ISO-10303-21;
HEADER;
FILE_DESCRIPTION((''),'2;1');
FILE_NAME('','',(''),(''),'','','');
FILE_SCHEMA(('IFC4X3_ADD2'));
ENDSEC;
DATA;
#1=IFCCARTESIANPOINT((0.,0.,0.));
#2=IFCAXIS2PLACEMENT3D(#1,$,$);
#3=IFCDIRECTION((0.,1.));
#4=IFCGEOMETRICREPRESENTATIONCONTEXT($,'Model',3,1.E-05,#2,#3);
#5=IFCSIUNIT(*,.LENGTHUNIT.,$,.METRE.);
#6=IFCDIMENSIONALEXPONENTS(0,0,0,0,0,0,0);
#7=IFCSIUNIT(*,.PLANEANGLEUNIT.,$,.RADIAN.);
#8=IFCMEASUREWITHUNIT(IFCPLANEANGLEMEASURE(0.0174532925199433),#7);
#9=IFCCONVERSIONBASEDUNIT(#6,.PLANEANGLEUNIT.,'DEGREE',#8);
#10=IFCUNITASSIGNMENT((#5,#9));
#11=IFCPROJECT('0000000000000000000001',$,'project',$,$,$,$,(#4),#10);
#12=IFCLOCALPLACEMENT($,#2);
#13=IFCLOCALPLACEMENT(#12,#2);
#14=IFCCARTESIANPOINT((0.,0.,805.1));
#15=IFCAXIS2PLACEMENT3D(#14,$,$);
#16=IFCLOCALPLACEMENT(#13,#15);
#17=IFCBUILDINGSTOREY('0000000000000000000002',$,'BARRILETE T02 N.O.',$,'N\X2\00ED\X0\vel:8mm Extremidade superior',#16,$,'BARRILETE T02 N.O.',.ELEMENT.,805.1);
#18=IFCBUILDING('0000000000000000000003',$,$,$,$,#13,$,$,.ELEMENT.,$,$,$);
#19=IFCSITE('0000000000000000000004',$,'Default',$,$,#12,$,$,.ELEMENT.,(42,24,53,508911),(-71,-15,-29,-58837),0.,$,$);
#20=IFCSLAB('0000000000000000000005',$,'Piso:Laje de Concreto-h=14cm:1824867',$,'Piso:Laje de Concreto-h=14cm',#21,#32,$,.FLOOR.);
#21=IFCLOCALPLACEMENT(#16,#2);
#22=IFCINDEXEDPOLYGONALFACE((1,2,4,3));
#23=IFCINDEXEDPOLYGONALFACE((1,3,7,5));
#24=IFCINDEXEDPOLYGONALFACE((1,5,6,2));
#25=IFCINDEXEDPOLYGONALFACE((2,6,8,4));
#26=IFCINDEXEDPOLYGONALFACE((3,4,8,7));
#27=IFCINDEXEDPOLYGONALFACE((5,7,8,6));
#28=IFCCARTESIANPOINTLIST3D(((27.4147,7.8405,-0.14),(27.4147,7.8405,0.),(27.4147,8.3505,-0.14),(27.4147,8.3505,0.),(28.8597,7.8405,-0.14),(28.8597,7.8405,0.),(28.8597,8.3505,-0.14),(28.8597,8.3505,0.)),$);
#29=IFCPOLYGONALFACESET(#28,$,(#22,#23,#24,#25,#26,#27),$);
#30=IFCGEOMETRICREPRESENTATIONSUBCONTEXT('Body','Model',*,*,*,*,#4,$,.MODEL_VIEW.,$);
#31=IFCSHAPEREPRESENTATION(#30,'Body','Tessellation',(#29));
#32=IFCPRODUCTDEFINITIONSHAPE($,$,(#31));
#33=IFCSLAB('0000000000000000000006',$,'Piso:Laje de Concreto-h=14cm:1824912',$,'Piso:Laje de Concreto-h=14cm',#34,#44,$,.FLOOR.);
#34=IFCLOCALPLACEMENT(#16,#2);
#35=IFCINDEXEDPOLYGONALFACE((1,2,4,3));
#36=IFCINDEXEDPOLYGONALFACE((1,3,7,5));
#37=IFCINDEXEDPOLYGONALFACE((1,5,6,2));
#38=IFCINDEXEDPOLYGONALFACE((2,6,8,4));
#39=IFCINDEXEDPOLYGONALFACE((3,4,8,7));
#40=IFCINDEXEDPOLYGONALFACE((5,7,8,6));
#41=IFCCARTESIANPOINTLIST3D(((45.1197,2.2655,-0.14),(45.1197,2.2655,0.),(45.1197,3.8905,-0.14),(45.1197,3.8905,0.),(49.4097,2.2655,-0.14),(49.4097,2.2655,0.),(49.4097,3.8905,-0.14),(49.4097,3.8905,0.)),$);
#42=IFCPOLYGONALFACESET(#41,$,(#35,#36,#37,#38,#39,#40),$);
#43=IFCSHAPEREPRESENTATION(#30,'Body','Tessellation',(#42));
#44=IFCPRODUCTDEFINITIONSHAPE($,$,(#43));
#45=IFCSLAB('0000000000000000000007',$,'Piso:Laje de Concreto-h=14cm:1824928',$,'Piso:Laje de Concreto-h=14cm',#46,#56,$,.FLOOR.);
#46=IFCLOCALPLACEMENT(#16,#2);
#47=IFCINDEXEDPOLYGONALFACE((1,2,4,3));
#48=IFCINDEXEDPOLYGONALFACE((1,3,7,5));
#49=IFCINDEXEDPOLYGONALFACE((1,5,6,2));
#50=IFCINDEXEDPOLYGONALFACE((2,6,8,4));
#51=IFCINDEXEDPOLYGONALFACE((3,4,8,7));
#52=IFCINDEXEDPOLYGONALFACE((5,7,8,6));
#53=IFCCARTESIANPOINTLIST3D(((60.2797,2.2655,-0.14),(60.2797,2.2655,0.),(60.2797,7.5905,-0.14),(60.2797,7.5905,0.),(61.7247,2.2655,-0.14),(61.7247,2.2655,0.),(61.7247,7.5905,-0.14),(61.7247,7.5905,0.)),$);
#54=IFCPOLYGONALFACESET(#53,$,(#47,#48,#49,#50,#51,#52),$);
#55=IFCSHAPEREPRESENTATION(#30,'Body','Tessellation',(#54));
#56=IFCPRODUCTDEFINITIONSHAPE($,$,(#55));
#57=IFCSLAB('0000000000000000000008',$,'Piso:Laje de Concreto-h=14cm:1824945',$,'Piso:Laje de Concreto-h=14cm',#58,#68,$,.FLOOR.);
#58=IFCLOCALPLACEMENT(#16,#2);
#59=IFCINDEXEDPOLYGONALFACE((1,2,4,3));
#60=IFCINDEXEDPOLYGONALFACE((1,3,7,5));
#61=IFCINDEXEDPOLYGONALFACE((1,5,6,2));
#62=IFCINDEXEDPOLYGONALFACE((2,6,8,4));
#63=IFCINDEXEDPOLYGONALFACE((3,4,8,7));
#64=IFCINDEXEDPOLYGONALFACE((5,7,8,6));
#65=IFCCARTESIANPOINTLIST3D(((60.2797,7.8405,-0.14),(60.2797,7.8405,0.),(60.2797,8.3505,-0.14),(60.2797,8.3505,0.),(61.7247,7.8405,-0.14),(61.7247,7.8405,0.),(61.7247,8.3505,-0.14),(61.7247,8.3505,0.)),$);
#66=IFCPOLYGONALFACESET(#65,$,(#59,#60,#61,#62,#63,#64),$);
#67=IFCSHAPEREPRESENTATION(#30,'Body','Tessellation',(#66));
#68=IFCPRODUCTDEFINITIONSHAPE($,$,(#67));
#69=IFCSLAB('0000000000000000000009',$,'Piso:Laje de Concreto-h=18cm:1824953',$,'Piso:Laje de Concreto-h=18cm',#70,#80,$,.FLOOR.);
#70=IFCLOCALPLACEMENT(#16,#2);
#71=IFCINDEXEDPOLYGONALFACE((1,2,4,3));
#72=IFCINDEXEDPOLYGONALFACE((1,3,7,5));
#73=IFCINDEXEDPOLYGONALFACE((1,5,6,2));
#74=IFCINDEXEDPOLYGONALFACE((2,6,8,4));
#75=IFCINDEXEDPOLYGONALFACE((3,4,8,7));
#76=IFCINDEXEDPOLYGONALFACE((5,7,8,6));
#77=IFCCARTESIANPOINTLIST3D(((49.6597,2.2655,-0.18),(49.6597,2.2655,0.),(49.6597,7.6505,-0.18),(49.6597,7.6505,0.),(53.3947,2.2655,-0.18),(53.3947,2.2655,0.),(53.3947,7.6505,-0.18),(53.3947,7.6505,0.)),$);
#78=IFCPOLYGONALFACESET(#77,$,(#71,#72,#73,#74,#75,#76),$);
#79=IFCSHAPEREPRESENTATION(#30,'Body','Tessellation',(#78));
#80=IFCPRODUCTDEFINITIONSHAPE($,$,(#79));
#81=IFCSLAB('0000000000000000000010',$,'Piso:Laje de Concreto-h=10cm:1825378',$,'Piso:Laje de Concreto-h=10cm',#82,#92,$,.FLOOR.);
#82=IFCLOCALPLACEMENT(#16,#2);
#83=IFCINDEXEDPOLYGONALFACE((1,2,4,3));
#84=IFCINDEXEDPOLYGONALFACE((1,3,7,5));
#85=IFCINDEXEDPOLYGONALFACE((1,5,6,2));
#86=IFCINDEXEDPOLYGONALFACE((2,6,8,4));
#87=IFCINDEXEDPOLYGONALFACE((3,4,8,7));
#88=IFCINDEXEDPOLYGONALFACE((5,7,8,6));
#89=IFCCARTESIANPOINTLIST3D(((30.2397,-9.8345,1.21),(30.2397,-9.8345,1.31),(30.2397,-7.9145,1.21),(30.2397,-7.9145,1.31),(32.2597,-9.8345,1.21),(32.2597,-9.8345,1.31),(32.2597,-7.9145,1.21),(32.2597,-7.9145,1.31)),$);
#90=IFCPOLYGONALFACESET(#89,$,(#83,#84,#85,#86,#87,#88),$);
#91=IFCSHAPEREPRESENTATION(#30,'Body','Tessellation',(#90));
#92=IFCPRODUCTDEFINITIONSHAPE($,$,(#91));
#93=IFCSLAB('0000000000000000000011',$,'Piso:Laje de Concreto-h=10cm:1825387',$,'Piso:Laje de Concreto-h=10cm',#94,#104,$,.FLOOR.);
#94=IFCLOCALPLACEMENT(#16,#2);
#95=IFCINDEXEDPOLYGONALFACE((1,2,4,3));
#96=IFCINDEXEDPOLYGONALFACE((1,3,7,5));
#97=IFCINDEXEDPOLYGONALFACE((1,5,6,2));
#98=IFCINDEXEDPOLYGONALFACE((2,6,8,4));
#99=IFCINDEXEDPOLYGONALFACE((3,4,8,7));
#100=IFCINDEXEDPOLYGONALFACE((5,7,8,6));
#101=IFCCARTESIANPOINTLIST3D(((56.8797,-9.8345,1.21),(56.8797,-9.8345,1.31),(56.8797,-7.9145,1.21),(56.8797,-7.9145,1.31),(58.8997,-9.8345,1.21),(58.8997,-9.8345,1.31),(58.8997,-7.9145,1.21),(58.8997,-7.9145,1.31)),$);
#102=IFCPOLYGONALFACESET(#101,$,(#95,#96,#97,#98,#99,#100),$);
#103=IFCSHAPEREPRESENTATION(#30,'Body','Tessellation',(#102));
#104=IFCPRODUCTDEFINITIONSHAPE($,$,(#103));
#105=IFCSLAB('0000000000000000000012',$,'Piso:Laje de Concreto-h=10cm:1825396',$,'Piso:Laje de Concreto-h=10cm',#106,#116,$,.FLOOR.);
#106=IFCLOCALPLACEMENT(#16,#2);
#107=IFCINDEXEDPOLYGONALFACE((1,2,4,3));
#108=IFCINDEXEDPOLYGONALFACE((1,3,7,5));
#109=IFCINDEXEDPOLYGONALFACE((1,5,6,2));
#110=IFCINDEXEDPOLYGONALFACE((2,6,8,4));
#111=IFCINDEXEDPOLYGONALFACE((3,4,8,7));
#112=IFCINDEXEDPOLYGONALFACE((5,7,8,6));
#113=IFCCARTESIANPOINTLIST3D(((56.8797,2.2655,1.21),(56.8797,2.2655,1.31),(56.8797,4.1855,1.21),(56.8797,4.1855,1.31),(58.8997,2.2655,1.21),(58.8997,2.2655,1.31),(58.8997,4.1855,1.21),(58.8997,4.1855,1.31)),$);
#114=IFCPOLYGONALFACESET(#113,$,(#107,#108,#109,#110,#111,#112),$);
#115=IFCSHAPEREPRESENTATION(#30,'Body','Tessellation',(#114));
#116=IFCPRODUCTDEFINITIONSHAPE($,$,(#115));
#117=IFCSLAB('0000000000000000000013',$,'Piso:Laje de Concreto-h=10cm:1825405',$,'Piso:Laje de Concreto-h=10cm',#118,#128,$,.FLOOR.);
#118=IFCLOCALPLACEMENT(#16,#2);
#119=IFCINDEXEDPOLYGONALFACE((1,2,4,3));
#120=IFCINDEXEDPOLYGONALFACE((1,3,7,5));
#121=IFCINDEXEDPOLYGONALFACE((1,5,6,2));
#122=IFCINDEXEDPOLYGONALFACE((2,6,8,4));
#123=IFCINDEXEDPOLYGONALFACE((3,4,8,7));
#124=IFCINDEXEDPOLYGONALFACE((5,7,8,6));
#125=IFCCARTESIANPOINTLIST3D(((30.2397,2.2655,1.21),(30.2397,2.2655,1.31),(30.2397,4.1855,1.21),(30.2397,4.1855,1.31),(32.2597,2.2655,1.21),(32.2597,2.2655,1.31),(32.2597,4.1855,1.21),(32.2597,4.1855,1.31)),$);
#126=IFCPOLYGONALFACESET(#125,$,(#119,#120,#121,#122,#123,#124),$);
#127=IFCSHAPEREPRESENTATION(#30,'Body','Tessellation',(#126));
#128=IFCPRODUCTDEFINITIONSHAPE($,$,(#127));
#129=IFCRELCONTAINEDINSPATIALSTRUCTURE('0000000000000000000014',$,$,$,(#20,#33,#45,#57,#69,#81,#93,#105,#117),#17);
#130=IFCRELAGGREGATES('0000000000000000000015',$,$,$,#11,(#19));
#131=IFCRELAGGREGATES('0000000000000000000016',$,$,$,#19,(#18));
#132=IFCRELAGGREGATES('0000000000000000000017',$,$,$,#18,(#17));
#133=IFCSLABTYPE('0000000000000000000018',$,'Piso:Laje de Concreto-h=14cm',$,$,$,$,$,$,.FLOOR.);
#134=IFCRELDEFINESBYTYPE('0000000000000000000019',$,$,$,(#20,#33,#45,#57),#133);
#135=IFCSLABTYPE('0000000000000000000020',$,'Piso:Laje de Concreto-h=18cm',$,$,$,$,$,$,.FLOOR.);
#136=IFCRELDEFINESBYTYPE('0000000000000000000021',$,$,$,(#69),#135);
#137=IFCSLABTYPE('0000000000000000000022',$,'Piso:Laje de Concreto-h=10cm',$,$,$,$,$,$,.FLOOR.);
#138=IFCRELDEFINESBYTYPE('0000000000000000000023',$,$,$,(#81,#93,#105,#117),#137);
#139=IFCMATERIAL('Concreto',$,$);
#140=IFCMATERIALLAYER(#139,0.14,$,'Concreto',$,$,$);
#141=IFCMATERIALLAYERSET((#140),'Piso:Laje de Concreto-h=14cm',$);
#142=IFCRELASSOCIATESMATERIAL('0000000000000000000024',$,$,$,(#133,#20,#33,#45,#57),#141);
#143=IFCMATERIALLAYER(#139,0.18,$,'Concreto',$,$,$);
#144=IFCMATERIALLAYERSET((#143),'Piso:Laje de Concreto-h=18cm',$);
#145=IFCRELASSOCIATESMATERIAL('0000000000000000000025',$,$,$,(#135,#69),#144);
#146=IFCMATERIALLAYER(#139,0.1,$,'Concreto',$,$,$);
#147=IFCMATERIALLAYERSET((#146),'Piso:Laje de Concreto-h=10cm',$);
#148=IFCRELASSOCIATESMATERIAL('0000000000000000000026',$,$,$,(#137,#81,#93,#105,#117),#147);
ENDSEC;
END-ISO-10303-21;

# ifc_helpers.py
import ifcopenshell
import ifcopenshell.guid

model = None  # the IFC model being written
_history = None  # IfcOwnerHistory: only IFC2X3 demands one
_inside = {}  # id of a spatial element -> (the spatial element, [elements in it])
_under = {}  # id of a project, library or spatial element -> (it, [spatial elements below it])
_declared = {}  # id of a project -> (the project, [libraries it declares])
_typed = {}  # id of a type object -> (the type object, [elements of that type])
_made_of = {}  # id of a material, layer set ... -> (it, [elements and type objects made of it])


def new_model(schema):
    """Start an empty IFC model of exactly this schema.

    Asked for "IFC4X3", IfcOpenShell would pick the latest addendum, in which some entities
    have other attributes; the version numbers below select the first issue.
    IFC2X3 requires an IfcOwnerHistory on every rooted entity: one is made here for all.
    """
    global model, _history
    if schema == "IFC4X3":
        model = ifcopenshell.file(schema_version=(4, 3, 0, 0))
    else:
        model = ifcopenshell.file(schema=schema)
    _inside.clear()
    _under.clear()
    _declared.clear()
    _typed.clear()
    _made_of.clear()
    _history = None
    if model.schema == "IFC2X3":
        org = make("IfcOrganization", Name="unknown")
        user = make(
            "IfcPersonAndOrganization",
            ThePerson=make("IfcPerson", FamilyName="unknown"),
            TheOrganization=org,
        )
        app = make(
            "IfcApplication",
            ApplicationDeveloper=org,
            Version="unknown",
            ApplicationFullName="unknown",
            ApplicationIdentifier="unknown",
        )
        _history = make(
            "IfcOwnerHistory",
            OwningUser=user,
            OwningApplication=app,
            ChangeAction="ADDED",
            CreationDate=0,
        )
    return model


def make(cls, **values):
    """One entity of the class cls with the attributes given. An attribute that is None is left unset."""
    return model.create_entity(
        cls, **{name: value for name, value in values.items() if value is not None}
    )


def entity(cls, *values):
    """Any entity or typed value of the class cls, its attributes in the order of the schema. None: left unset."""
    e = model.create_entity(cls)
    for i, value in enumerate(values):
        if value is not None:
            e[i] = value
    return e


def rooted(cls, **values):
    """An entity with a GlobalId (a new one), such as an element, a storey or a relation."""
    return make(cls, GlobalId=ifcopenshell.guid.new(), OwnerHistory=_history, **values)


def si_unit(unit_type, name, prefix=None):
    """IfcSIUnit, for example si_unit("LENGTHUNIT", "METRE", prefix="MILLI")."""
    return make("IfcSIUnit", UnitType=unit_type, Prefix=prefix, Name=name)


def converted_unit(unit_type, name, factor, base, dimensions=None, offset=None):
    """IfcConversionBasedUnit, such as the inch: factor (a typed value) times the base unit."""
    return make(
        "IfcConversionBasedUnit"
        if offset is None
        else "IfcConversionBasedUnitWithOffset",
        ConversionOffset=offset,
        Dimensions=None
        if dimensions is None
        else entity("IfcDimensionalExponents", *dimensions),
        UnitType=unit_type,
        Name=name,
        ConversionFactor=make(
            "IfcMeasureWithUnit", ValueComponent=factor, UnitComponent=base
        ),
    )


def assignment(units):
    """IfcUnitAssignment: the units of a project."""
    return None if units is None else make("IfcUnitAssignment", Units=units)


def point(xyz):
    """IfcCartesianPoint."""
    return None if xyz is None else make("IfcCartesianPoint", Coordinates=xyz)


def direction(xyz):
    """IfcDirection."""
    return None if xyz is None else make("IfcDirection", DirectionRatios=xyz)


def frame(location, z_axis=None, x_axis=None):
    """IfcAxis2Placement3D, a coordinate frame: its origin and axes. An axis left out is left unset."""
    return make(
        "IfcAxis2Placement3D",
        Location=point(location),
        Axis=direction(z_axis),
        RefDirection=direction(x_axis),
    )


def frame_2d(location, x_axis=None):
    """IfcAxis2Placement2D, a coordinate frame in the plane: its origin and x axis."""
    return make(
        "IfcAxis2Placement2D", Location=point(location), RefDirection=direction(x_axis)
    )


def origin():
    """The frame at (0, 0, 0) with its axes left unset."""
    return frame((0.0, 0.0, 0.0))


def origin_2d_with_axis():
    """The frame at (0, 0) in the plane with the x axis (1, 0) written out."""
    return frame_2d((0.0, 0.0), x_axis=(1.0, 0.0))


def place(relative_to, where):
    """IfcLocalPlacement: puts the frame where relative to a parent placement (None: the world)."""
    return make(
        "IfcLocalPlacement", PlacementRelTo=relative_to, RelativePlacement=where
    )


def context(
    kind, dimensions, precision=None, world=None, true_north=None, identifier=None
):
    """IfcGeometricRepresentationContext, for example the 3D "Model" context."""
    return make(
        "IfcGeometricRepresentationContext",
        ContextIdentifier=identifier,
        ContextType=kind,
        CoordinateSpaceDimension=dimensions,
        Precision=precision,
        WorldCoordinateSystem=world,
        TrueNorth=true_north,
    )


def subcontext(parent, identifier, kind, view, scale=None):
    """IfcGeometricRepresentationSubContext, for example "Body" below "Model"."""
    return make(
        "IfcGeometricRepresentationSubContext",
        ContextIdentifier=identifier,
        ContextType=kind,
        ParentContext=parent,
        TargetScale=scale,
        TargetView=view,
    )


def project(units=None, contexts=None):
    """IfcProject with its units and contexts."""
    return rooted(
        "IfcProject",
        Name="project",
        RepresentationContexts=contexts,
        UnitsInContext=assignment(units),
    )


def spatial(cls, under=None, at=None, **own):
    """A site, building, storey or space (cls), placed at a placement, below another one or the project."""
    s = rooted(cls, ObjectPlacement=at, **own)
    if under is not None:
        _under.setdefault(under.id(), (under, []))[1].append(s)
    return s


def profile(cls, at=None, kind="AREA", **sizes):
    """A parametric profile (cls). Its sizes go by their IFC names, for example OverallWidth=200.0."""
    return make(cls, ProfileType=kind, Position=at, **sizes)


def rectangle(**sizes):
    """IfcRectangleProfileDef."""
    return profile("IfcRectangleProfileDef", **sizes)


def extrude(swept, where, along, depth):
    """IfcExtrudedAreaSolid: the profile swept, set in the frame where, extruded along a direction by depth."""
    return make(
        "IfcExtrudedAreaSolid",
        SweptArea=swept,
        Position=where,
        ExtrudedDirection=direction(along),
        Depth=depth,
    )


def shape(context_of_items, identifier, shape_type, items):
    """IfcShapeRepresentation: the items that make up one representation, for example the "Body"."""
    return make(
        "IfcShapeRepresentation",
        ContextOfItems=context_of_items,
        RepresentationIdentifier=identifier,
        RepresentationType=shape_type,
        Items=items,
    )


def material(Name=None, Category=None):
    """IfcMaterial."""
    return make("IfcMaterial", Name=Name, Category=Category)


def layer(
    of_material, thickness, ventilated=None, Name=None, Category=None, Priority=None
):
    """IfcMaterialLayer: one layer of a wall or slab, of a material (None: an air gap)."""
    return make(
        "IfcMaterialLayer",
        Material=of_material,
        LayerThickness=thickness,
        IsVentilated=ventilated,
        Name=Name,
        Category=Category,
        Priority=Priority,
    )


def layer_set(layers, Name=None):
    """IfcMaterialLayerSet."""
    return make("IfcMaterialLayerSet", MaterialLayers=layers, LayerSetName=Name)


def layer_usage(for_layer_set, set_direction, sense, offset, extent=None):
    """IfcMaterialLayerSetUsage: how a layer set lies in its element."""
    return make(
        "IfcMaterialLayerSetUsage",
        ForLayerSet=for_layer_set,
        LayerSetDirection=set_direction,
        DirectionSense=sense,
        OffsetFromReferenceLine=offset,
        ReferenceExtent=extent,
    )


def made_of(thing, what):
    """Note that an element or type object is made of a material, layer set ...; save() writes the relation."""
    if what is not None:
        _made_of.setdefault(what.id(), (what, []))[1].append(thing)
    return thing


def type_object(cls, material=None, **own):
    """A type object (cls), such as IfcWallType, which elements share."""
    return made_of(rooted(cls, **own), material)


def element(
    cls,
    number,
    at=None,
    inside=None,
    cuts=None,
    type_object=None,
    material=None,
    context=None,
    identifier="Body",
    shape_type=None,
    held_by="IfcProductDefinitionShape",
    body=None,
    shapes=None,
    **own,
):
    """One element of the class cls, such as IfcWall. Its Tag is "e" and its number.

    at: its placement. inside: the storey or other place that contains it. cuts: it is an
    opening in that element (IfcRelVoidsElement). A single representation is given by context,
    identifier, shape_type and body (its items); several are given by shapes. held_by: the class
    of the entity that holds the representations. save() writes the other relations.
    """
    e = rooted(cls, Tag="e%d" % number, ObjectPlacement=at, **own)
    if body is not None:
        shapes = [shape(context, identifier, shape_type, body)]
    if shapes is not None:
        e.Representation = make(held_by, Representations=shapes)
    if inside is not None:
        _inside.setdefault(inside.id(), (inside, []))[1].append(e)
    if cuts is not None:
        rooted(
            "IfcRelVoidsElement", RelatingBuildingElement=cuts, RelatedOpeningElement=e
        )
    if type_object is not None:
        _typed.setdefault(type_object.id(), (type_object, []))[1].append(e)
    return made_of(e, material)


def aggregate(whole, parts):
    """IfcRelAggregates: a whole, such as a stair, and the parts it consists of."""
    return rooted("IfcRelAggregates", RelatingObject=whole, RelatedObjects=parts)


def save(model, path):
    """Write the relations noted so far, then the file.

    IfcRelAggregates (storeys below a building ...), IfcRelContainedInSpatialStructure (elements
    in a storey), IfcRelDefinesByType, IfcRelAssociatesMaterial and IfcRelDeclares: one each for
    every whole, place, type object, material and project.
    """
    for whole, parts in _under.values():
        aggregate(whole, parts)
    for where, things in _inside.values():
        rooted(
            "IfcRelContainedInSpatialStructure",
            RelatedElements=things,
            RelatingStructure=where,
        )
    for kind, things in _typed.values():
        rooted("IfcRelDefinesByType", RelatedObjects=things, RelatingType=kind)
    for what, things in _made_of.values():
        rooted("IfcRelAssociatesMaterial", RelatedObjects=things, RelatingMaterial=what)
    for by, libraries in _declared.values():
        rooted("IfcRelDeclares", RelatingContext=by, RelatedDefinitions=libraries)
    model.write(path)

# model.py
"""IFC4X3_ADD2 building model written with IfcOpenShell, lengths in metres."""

from ifc_helpers import new_model, entity, si_unit, converted_unit, direction, frame, frame_2d, origin, origin_2d_with_axis, place, context, subcontext, project, spatial, rectangle, extrude, material, layer, layer_set, layer_usage, type_object, element, save


model = new_model("IFC4X3_ADD2")

# Units and contexts
model_context = context("Model", 3, precision=1e-05, world=origin(), true_north=direction((0.0, 1.0)))
body_context = subcontext(model_context, "Body", "Model", "MODEL_VIEW")
ifc_project = project(units=[si_unit("LENGTHUNIT", "METRE"), converted_unit("PLANEANGLEUNIT", "DEGREE", entity("IfcPlaneAngleMeasure", 0.0174532925199433), si_unit("PLANEANGLEUNIT", "RADIAN"), dimensions=[0, 0, 0, 0, 0, 0, 0])], contexts=[model_context])

# Site, building, storey
site_placement = place(None, origin())
site = spatial("IfcSite", under=ifc_project, at=site_placement, Name="Default", CompositionType="ELEMENT", RefLatitude=(42, 24, 53, 508911), RefLongitude=(-71, -15, -29, -58837), RefElevation=0.0)
building_placement = place(site_placement, origin())
building = spatial("IfcBuilding", under=site, at=building_placement, CompositionType="ELEMENT")
storey_placement = place(building_placement, frame((0.0, 0.0, 805.1)))
storey = spatial("IfcBuildingStorey", under=building, at=storey_placement, Name="BARRILETE T02 N.O.", ObjectType="Nível:8mm Extremidade superior", LongName="BARRILETE T02 N.O.", CompositionType="ELEMENT", Elevation=805.1)

# Shared definitions
ifc_material = material(Name="Concreto")

# Slabs
ifc_layer_1 = layer(ifc_material, 0.14, Name="Concreto")
ifc_layer_set_1 = layer_set([ifc_layer_1], Name="Piso:Laje de Concreto-h=14cm")
ifc_layer_usage_1 = layer_usage(ifc_layer_set_1, "AXIS3", "POSITIVE", 0.0)
slab_type_1 = type_object("IfcSlabType", Name="Piso:Laje de Concreto-h=14cm", PredefinedType="FLOOR", material=ifc_layer_set_1)
slab_1_placement = place(storey_placement, origin())
element("IfcSlab", 1, at=slab_1_placement, inside=storey, type_object=slab_type_1, material=ifc_layer_usage_1, Name="Piso:Laje de Concreto-h=14cm:1824867", ObjectType="Piso:Laje de Concreto-h=14cm", PredefinedType="FLOOR", context=body_context, shape_type="SweptSolid", body=[
    extrude(rectangle(XDim=0.51, YDim=1.445, at=frame_2d((0.0, 0.0), x_axis=(1.0, 0.0))), frame((28.1372, 8.0955, 0.0), z_axis=(0.0, 0.0, -1.0), x_axis=(0.0, 1.0, 0.0)), (0.0, 0.0, 1.0), 0.14),
])
ifc_layer_usage_2 = layer_usage(ifc_layer_set_1, "AXIS3", "POSITIVE", 0.0)
slab_2_placement = place(storey_placement, origin())
element("IfcSlab", 2, at=slab_2_placement, inside=storey, type_object=slab_type_1, material=ifc_layer_usage_2, Name="Piso:Laje de Concreto-h=14cm:1824912", ObjectType="Piso:Laje de Concreto-h=14cm", PredefinedType="FLOOR", context=body_context, shape_type="SweptSolid", body=[
    extrude(rectangle(XDim=1.625, YDim=4.29, at=frame_2d((0.0, 0.0), x_axis=(1.0, 0.0))), frame((47.2647, 3.078, 0.0), z_axis=(0.0, 0.0, -1.0), x_axis=(0.0, 1.0, 0.0)), (0.0, 0.0, 1.0), 0.14),
])
ifc_layer_usage_3 = layer_usage(ifc_layer_set_1, "AXIS3", "POSITIVE", 0.0)
slab_3_placement = place(storey_placement, origin())
element("IfcSlab", 3, at=slab_3_placement, inside=storey, type_object=slab_type_1, material=ifc_layer_usage_3, Name="Piso:Laje de Concreto-h=14cm:1824928", ObjectType="Piso:Laje de Concreto-h=14cm", PredefinedType="FLOOR", context=body_context, shape_type="SweptSolid", body=[
    extrude(rectangle(XDim=5.325, YDim=1.445, at=frame_2d((0.0, 0.0), x_axis=(1.0, 0.0))), frame((61.0022, 4.928, 0.0), z_axis=(0.0, 0.0, -1.0), x_axis=(0.0, 1.0, 0.0)), (0.0, 0.0, 1.0), 0.14),
])
ifc_layer_usage_4 = layer_usage(ifc_layer_set_1, "AXIS3", "POSITIVE", 0.0)
slab_4_placement = place(storey_placement, origin())
element("IfcSlab", 4, at=slab_4_placement, inside=storey, type_object=slab_type_1, material=ifc_layer_usage_4, Name="Piso:Laje de Concreto-h=14cm:1824945", ObjectType="Piso:Laje de Concreto-h=14cm", PredefinedType="FLOOR", context=body_context, shape_type="SweptSolid", body=[
    extrude(rectangle(XDim=0.51, YDim=1.445, at=frame_2d((0.0, 0.0), x_axis=(1.0, 0.0))), frame((61.0022, 8.0955, 0.0), z_axis=(0.0, 0.0, -1.0), x_axis=(0.0, 1.0, 0.0)), (0.0, 0.0, 1.0), 0.14),
])
ifc_layer_2 = layer(ifc_material, 0.18, Name="Concreto")
ifc_layer_set_2 = layer_set([ifc_layer_2], Name="Piso:Laje de Concreto-h=18cm")
ifc_layer_usage_5 = layer_usage(ifc_layer_set_2, "AXIS3", "POSITIVE", 0.0)
slab_type_2 = type_object("IfcSlabType", Name="Piso:Laje de Concreto-h=18cm", PredefinedType="FLOOR", material=ifc_layer_set_2)
slab_5_placement = place(storey_placement, origin())
element("IfcSlab", 5, at=slab_5_placement, inside=storey, type_object=slab_type_2, material=ifc_layer_usage_5, Name="Piso:Laje de Concreto-h=18cm:1824953", ObjectType="Piso:Laje de Concreto-h=18cm", PredefinedType="FLOOR", context=body_context, shape_type="SweptSolid", body=[
    extrude(rectangle(XDim=5.385, YDim=3.735, at=origin_2d_with_axis()), frame((51.5272, 4.958, 0.0), z_axis=(0.0, 0.0, -1.0), x_axis=(0.0, 1.0, 0.0)), (0.0, 0.0, 1.0), 0.18),
])
ifc_layer_3 = layer(ifc_material, 0.1, Name="Concreto")
ifc_layer_set_3 = layer_set([ifc_layer_3], Name="Piso:Laje de Concreto-h=10cm")
ifc_layer_usage_6 = layer_usage(ifc_layer_set_3, "AXIS3", "POSITIVE", 0.0)
slab_type_3 = type_object("IfcSlabType", Name="Piso:Laje de Concreto-h=10cm", PredefinedType="FLOOR", material=ifc_layer_set_3)
slab_6_placement = place(storey_placement, origin())
element("IfcSlab", 6, at=slab_6_placement, inside=storey, type_object=slab_type_3, material=ifc_layer_usage_6, Name="Piso:Laje de Concreto-h=10cm:1825378", ObjectType="Piso:Laje de Concreto-h=10cm", PredefinedType="FLOOR", context=body_context, shape_type="SweptSolid", body=[
    extrude(rectangle(XDim=1.92, YDim=2.02, at=frame_2d((0.0, 0.0), x_axis=(1.0, 0.0))), frame((31.2497, -8.8745, 1.31), z_axis=(0.0, 0.0, -1.0), x_axis=(0.0, 1.0, 0.0)), (0.0, 0.0, 1.0), 0.1),
])
ifc_layer_usage_7 = layer_usage(ifc_layer_set_3, "AXIS3", "POSITIVE", 0.0)
slab_7_placement = place(storey_placement, origin())
element("IfcSlab", 7, at=slab_7_placement, inside=storey, type_object=slab_type_3, material=ifc_layer_usage_7, Name="Piso:Laje de Concreto-h=10cm:1825387", ObjectType="Piso:Laje de Concreto-h=10cm", PredefinedType="FLOOR", context=body_context, shape_type="SweptSolid", body=[
    extrude(rectangle(XDim=1.92, YDim=2.02, at=frame_2d((0.0, 0.0), x_axis=(1.0, 0.0))), frame((57.8897, -8.8745, 1.31), z_axis=(0.0, 0.0, -1.0), x_axis=(0.0, 1.0, 0.0)), (0.0, 0.0, 1.0), 0.1),
])
ifc_layer_usage_8 = layer_usage(ifc_layer_set_3, "AXIS3", "POSITIVE", 0.0)
slab_8_placement = place(storey_placement, origin())
element("IfcSlab", 8, at=slab_8_placement, inside=storey, type_object=slab_type_3, material=ifc_layer_usage_8, Name="Piso:Laje de Concreto-h=10cm:1825396", ObjectType="Piso:Laje de Concreto-h=10cm", PredefinedType="FLOOR", context=body_context, shape_type="SweptSolid", body=[
    extrude(rectangle(XDim=1.92, YDim=2.02, at=frame_2d((0.0, 0.0), x_axis=(1.0, 0.0))), frame((57.8897, 3.2255, 1.31), z_axis=(0.0, 0.0, -1.0), x_axis=(0.0, 1.0, 0.0)), (0.0, 0.0, 1.0), 0.1),
])
ifc_layer_usage_9 = layer_usage(ifc_layer_set_3, "AXIS3", "POSITIVE", 0.0)
slab_9_placement = place(storey_placement, origin())
element("IfcSlab", 9, at=slab_9_placement, inside=storey, type_object=slab_type_3, material=ifc_layer_usage_9, Name="Piso:Laje de Concreto-h=10cm:1825405", ObjectType="Piso:Laje de Concreto-h=10cm", PredefinedType="FLOOR", context=body_context, shape_type="SweptSolid", body=[
    extrude(rectangle(XDim=1.92, YDim=2.02, at=origin_2d_with_axis()), frame((31.2497, 3.2255, 1.31), z_axis=(0.0, 0.0, -1.0), x_axis=(0.0, 1.0, 0.0)), (0.0, 0.0, 1.0), 0.1),
])

save(model, "model.ifc")
